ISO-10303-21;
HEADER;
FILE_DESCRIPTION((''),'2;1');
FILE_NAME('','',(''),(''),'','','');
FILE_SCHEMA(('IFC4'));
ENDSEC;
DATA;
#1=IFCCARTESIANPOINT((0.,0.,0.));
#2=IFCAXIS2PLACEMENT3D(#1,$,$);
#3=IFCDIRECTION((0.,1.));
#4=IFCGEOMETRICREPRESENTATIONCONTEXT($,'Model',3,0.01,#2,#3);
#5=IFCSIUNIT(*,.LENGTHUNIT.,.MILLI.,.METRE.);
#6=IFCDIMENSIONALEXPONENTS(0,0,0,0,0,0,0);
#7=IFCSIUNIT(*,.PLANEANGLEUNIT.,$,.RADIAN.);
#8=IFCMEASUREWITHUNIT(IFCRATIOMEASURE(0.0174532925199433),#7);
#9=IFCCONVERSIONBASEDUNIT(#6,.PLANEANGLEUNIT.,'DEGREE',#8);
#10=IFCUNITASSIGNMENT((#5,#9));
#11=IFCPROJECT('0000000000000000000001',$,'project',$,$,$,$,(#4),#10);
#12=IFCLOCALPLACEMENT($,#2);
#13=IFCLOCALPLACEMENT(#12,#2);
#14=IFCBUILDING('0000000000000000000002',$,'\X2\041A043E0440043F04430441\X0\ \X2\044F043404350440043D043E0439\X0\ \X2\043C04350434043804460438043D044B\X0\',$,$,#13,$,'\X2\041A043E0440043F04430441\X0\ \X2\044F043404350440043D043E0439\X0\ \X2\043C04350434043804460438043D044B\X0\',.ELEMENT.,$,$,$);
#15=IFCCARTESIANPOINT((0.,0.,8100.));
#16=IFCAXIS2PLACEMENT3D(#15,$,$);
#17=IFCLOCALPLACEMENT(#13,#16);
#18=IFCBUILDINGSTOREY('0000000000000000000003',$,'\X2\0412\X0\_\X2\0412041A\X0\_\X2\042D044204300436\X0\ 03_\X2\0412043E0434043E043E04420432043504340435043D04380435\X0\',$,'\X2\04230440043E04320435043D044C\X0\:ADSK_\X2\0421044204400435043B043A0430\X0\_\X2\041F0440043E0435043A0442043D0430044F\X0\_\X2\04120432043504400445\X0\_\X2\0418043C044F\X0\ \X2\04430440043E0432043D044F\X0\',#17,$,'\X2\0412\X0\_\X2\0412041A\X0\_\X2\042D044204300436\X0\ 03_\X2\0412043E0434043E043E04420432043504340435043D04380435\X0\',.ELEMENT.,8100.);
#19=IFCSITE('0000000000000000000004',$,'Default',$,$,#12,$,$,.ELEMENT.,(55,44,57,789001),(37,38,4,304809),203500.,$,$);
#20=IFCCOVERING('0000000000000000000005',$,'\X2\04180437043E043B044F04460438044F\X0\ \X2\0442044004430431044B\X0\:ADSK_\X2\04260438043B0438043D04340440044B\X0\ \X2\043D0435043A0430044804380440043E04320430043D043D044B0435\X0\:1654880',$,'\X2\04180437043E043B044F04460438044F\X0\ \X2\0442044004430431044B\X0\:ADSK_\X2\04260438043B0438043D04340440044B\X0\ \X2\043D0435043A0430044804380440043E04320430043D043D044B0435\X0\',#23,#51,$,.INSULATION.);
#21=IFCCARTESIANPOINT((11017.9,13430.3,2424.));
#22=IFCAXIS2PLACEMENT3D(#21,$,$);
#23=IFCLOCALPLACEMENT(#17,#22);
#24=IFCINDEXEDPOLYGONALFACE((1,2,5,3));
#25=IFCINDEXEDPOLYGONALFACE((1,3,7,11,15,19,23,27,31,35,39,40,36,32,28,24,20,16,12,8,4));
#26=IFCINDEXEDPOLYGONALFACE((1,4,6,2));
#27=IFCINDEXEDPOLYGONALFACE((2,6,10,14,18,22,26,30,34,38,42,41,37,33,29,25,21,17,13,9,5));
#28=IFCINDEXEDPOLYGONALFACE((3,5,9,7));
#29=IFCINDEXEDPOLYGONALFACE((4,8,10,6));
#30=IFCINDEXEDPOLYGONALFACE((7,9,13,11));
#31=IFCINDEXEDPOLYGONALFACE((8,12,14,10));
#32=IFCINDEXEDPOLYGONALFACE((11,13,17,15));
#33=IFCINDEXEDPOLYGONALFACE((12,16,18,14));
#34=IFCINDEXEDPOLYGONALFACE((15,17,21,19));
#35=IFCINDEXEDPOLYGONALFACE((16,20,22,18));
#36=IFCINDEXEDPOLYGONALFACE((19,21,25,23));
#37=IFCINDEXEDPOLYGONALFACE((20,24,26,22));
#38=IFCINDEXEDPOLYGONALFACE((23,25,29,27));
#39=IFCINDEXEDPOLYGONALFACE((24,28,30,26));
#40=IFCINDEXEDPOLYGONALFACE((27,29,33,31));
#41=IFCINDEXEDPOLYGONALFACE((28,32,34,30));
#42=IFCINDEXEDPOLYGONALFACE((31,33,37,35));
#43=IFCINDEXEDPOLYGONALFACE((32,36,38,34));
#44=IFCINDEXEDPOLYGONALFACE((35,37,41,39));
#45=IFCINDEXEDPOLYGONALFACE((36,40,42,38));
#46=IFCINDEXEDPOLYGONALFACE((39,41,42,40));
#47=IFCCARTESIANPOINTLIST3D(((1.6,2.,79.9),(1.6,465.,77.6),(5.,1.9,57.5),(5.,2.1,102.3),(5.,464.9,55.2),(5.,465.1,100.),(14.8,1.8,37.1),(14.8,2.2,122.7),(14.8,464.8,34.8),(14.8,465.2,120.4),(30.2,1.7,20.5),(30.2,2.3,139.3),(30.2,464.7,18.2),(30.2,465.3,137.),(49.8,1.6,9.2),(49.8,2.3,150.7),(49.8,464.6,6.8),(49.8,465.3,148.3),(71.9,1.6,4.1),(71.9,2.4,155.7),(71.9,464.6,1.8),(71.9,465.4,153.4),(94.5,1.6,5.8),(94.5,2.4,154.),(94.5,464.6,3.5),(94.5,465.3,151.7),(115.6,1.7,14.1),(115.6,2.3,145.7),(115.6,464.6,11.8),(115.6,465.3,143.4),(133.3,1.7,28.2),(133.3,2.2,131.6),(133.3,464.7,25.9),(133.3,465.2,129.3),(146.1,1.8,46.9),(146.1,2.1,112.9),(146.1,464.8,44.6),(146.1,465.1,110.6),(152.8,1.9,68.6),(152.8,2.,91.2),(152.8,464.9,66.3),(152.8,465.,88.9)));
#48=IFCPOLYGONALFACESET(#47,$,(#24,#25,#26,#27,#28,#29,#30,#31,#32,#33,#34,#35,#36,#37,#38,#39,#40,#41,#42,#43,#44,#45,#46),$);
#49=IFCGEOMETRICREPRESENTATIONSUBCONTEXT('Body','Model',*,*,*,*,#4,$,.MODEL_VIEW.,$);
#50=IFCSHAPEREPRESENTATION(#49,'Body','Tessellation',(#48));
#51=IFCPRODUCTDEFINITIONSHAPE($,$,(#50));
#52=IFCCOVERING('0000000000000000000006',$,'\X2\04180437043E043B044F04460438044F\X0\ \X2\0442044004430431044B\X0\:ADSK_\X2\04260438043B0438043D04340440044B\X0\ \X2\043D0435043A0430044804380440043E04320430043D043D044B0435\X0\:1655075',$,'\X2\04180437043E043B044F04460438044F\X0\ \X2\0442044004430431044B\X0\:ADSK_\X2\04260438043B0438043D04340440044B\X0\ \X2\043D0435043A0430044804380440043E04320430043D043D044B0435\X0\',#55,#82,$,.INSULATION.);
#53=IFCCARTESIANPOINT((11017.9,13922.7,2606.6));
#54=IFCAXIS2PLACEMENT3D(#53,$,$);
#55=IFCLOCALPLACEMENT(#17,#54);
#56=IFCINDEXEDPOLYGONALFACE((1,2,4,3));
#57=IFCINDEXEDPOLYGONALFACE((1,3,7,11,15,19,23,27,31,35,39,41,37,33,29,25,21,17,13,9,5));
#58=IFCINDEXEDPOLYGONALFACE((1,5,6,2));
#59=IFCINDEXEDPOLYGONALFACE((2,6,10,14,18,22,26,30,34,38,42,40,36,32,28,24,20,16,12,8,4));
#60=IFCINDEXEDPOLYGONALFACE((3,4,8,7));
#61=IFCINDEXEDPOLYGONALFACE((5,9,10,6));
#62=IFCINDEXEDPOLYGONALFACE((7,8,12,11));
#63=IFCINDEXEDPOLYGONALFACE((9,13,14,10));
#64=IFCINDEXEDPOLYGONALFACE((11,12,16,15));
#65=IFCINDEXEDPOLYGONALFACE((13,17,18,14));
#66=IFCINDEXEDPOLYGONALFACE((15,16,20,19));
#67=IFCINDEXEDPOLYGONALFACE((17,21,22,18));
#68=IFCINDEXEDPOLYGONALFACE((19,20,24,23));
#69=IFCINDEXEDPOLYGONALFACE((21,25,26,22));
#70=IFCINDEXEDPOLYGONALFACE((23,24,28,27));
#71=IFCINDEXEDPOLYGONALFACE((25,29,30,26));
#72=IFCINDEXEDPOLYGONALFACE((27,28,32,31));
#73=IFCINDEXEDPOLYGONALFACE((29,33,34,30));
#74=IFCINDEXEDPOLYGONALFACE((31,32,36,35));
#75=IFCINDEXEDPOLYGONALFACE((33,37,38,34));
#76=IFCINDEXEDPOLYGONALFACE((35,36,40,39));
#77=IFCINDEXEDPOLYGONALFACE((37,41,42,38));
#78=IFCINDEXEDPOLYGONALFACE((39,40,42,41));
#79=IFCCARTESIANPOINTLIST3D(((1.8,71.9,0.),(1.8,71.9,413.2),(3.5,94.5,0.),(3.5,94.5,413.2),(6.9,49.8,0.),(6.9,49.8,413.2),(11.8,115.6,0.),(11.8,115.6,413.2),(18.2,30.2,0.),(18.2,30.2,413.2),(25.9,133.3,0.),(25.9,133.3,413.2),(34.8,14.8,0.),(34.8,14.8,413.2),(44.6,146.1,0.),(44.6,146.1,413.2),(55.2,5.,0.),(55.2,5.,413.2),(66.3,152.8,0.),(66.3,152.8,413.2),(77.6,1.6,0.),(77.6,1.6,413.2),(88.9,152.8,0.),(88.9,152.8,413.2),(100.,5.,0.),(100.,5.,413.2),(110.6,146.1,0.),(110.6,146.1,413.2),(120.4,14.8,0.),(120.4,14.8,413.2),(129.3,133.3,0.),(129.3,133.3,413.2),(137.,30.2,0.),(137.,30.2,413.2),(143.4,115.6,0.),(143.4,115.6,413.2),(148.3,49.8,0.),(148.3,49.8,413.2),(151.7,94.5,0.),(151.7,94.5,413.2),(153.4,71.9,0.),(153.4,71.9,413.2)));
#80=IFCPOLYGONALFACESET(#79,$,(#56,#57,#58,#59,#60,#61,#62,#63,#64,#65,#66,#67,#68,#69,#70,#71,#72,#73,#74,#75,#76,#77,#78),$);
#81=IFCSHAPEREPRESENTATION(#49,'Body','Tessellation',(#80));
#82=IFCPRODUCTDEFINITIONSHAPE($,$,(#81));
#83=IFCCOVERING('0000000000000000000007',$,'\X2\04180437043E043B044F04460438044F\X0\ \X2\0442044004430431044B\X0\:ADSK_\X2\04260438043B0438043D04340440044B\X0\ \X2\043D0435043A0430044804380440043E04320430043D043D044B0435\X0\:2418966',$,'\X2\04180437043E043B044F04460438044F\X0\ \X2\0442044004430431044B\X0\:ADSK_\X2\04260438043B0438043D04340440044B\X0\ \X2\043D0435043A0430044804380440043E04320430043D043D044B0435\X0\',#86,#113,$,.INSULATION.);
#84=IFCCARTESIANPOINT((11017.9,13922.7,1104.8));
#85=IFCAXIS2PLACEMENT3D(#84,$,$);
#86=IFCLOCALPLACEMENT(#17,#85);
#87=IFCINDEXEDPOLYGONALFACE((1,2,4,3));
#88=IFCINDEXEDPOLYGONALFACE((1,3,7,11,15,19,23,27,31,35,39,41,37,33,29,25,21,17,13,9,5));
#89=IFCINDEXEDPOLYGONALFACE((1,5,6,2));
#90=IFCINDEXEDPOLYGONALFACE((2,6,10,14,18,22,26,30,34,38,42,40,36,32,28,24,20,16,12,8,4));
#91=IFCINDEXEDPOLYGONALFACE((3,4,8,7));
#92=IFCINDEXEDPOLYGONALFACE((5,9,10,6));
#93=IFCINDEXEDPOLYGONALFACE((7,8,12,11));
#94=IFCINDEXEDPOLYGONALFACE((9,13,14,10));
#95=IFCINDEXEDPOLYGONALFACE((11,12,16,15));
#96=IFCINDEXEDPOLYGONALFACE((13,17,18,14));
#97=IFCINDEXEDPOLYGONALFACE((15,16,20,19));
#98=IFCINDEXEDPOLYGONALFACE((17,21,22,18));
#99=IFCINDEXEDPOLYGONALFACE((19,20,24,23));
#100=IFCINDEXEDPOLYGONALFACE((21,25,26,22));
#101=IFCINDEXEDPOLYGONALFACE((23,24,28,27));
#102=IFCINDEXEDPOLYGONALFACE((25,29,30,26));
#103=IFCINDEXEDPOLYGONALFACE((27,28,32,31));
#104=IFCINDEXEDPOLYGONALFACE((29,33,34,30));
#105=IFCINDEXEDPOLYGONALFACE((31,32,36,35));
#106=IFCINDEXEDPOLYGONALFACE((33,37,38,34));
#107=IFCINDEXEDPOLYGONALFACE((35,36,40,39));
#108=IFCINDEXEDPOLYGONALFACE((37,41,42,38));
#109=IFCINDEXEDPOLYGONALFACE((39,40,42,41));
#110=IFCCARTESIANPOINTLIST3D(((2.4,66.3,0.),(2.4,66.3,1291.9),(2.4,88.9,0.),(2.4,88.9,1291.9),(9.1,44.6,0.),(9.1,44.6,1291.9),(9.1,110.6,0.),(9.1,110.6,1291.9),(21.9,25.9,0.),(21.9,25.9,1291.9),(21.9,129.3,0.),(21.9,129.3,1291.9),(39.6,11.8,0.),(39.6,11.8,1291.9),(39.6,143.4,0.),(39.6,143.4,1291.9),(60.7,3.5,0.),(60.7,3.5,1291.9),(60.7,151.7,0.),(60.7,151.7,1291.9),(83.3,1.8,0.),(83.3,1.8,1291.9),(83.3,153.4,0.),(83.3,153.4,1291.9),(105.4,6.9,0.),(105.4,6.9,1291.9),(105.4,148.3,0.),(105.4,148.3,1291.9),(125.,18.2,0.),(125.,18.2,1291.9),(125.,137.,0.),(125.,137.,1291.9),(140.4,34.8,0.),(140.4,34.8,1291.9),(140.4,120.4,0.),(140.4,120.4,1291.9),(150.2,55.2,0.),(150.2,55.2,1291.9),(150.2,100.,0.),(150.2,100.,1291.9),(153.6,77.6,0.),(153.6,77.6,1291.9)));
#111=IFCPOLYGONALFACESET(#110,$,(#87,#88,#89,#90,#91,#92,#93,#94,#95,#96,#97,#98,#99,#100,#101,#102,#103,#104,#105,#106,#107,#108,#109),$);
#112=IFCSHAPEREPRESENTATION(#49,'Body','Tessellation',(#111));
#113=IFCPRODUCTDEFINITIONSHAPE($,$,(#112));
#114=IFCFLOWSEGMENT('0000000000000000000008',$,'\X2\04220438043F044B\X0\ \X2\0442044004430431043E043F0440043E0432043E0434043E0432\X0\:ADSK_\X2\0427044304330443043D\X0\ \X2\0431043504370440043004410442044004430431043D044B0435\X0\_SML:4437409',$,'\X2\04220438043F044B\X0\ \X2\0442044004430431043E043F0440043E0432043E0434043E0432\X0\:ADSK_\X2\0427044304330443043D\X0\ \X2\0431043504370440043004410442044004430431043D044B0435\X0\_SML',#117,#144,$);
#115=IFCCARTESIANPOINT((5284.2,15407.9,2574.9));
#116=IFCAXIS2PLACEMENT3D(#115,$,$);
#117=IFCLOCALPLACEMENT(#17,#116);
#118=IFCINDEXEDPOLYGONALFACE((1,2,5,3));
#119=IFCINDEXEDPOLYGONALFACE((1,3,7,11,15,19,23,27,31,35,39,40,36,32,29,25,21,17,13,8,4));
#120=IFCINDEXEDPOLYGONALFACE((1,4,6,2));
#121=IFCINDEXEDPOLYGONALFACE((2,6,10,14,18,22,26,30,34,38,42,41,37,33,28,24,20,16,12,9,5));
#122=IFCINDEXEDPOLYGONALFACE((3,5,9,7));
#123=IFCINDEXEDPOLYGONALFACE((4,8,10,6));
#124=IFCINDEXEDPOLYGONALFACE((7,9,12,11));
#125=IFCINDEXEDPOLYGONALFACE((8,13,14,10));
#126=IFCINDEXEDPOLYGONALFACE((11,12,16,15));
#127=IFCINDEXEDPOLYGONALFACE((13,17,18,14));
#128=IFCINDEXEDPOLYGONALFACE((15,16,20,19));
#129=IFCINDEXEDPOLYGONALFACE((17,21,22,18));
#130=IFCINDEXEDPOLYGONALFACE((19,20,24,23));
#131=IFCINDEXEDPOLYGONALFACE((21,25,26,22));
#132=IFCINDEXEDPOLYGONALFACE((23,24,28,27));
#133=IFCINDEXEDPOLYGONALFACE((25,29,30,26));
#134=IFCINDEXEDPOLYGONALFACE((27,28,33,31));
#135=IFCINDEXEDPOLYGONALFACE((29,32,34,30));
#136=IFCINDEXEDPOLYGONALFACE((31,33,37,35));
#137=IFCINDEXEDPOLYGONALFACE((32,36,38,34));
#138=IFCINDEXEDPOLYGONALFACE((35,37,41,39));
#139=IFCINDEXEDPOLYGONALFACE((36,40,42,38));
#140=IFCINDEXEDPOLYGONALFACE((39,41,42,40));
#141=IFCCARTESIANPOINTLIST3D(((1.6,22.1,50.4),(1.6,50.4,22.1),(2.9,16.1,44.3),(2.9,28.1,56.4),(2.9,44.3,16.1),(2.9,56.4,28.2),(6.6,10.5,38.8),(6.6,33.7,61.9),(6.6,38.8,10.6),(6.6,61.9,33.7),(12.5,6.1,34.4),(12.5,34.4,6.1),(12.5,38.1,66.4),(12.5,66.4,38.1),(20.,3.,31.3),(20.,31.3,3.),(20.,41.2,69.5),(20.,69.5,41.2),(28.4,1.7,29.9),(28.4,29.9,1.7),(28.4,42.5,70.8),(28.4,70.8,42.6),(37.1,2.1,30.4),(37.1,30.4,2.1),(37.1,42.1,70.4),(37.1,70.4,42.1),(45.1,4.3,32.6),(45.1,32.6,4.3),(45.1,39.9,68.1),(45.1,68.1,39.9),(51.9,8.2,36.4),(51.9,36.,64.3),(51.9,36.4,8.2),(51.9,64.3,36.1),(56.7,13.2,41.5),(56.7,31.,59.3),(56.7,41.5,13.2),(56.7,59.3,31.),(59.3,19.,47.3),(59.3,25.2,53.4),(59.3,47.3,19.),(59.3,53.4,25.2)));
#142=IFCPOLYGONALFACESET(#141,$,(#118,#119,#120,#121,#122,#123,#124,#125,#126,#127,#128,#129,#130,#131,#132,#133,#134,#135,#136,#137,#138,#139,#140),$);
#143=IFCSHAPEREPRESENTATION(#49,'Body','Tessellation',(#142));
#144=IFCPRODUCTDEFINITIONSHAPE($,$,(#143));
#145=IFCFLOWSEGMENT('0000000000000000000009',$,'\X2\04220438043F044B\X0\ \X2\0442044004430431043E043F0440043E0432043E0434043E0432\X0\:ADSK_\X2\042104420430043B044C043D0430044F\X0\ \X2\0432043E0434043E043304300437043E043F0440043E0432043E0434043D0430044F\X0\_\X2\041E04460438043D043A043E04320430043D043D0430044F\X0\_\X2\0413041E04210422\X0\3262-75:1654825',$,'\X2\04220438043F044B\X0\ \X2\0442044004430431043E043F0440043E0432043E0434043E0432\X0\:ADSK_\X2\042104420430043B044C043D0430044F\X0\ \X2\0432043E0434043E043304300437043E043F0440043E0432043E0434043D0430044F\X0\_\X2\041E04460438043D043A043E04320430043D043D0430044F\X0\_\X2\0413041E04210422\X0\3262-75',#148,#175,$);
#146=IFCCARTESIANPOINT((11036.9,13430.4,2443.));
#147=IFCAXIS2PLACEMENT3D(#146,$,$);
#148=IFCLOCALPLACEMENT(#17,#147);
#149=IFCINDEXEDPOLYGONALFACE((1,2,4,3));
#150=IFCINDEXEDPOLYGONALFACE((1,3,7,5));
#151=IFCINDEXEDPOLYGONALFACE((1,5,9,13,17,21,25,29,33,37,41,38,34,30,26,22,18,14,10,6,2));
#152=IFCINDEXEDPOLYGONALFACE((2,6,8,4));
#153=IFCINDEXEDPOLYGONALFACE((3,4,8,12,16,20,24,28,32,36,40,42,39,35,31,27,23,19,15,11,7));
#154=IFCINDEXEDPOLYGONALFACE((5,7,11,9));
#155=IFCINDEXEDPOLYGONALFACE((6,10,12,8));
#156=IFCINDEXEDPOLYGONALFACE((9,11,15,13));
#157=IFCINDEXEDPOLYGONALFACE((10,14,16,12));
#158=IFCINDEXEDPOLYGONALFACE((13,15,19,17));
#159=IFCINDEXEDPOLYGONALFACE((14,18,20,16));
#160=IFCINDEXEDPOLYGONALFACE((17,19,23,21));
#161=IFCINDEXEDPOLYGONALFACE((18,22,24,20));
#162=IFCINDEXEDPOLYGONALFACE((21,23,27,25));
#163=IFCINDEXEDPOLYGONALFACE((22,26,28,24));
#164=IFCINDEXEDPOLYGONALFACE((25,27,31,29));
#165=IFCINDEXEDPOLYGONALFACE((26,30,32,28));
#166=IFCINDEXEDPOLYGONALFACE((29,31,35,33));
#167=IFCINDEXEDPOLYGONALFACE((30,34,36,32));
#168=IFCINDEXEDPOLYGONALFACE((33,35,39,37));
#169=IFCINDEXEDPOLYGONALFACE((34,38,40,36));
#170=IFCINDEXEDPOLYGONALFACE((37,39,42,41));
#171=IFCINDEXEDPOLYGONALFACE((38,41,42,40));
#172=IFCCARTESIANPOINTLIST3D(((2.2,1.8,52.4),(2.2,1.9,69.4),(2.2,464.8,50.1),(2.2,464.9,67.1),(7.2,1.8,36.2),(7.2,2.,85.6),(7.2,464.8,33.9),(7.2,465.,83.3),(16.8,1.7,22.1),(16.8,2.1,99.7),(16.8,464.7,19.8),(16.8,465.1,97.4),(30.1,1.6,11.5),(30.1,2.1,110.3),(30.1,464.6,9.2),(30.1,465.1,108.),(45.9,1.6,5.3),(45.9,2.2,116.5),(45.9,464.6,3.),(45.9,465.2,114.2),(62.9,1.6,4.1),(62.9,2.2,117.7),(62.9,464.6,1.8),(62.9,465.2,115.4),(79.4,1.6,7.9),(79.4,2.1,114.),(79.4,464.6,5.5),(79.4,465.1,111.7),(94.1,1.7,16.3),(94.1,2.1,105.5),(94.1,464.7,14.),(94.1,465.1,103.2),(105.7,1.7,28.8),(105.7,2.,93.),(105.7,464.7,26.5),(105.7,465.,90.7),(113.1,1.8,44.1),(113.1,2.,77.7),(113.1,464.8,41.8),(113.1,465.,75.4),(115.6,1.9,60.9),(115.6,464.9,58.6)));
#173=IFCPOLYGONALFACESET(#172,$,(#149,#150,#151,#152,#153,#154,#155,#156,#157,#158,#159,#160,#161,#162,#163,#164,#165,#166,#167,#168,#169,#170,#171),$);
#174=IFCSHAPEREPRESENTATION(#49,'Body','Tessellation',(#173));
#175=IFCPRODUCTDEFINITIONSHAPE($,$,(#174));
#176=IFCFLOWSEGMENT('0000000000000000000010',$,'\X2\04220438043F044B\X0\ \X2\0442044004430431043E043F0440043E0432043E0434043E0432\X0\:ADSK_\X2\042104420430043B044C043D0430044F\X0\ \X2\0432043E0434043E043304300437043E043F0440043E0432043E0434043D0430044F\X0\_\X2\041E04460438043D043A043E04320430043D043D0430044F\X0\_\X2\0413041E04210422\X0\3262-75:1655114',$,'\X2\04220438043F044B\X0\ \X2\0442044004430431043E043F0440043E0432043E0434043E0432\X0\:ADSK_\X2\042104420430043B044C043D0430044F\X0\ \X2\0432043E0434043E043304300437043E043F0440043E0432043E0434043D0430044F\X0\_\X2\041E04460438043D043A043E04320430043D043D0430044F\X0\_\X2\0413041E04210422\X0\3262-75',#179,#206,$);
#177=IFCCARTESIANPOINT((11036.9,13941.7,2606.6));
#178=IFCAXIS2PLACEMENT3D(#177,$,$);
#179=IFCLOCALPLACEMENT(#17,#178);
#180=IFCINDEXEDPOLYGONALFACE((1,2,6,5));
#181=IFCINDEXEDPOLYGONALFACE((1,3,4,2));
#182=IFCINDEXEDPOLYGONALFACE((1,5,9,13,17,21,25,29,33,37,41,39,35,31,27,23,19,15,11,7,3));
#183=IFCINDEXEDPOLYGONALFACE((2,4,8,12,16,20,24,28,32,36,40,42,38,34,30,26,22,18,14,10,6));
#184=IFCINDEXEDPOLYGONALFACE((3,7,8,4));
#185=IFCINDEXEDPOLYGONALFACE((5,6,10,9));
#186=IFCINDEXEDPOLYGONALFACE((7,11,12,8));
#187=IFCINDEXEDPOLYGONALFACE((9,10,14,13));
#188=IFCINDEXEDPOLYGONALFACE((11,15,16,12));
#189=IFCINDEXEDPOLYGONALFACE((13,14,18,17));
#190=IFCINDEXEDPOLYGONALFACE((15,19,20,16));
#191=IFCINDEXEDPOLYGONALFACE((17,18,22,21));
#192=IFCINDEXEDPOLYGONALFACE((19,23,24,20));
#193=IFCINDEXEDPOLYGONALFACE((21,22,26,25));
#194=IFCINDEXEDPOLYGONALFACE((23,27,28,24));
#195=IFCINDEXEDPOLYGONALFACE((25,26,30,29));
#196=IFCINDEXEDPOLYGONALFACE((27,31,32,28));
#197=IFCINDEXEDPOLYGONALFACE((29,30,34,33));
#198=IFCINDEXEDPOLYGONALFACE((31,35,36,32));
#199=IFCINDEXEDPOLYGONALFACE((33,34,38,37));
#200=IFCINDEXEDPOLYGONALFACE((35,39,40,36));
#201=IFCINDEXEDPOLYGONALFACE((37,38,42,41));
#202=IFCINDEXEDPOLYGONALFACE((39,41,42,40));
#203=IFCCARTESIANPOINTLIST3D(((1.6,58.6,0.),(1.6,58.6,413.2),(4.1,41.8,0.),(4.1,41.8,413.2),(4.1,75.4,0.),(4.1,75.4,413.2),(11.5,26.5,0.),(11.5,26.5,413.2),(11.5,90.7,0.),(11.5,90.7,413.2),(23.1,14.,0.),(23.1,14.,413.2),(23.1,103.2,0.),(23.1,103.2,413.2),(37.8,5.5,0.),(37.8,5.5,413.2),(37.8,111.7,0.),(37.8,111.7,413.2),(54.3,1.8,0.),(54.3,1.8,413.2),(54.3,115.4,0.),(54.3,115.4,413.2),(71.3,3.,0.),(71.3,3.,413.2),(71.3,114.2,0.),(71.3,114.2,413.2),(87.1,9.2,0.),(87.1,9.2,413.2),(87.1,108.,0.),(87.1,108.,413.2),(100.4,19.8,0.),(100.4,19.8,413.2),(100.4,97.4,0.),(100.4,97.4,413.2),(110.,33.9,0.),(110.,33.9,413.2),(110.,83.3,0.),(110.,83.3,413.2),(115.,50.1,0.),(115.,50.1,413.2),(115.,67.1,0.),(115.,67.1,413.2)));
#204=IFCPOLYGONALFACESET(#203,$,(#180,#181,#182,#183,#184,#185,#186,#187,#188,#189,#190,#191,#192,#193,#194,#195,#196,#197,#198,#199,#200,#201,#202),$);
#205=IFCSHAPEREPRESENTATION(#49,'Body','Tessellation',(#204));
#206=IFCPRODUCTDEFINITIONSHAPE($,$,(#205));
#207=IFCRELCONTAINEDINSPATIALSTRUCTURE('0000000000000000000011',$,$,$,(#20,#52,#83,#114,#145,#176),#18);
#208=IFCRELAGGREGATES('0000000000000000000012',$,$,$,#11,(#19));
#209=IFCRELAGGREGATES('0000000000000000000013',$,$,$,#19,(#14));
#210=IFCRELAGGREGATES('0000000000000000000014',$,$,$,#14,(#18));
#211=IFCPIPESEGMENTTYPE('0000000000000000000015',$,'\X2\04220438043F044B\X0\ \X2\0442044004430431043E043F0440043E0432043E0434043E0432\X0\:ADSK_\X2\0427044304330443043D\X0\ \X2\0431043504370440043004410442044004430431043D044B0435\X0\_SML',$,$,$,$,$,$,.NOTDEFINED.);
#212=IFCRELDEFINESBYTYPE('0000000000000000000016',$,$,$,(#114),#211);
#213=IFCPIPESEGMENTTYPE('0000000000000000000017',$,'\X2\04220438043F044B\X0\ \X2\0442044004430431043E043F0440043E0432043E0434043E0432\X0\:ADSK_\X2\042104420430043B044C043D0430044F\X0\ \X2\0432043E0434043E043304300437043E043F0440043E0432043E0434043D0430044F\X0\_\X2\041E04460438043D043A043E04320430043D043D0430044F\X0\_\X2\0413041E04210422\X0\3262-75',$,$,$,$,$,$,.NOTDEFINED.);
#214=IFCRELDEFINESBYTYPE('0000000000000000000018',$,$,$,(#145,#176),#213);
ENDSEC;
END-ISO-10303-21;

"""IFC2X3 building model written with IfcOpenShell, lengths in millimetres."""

from ifc_helpers import new_model, entity, si_unit, converted_unit, direction, frame, origin, origin_2d_with_axis, place, context, subcontext, project, spatial, circle, extrude, type_object, element, save


model = new_model("IFC2X3")

# Units and contexts
model_context = context("Model", 3, precision=0.01, world=origin(), true_north=direction((0.0, 1.0)))
body_context = subcontext(model_context, "Body", "Model", "MODEL_VIEW")
ifc_project = project(units=[si_unit("LENGTHUNIT", "METRE", prefix="MILLI"), converted_unit("PLANEANGLEUNIT", "DEGREE", entity("IfcRatioMeasure", 0.0174532925199433), si_unit("PLANEANGLEUNIT", "RADIAN"), dimensions=[0, 0, 0, 0, 0, 0, 0])], contexts=[model_context])

# Site, building, storey
site_placement = place(None, origin())
site = spatial("IfcSite", under=ifc_project, at=site_placement, Name="Default", CompositionType="ELEMENT", RefLatitude=(55, 44, 57, 789001), RefLongitude=(37, 38, 4, 304809), RefElevation=203500.0)
building_placement = place(site_placement, origin())
building = spatial("IfcBuilding", under=site, at=building_placement, Name="Корпус ядерной медицины", LongName="Корпус ядерной медицины", CompositionType="ELEMENT")
storey_placement = place(building_placement, frame((0.0, 0.0, 8100.0)))
storey = spatial("IfcBuildingStorey", under=building, at=storey_placement, Name="В_ВК_Этаж 03_Водоотведение", ObjectType="Уровень:ADSK_Стрелка_Проектная_Вверх_Имя уровня", LongName="В_ВК_Этаж 03_Водоотведение", CompositionType="ELEMENT", Elevation=8100.0)

# Coverings
covering_1_placement = place(storey_placement, frame((11017.9, 13430.3, 2424.0)))
element("IfcCovering", 1, at=covering_1_placement, inside=storey, Name="Изоляция трубы:ADSK_Цилиндры некашированные:1654880", ObjectType="Изоляция трубы:ADSK_Цилиндры некашированные", PredefinedType="INSULATION", context=body_context, shape_type="SweptSolid", body=[
    extrude(circle(Radius=76.0, at=origin_2d_with_axis()), frame((77.6, 2.0, 79.9), z_axis=(0.0, 0.999988, -0.005), x_axis=(-1.0, 0.0, 0.0)), (0.0, 0.0, 1.0), 463.0),
])
covering_2_placement = place(storey_placement, frame((11017.9, 13922.7, 2606.6)))
element("IfcCovering", 2, at=covering_2_placement, inside=storey, Name="Изоляция трубы:ADSK_Цилиндры некашированные:1655075", ObjectType="Изоляция трубы:ADSK_Цилиндры некашированные", PredefinedType="INSULATION", context=body_context, shape_type="SweptSolid", body=[
    extrude(circle(Radius=76.0, at=origin_2d_with_axis()), frame((77.6, 77.6, 0.0), z_axis=(0.0, 0.0, 1.0), x_axis=(0.0, -1.0, 0.0)), (0.0, 0.0, 1.0), 413.2),
])
covering_3_placement = place(storey_placement, frame((11017.9, 13922.7, 1104.8)))
element("IfcCovering", 3, at=covering_3_placement, inside=storey, Name="Изоляция трубы:ADSK_Цилиндры некашированные:2418966", ObjectType="Изоляция трубы:ADSK_Цилиндры некашированные", PredefinedType="INSULATION", context=body_context, shape_type="SweptSolid", body=[
    extrude(circle(Radius=76.0, at=origin_2d_with_axis()), frame((77.6, 77.6, 0.0)), (0.0, 0.0, 1.0), 1291.9),
])

# Flow segments
pipe_segment_type_1 = type_object("IfcPipeSegmentType", Name="Типы трубопроводов:ADSK_Чугун безраструбные_SML", PredefinedType="NOTDEFINED")
flow_segment_1_placement = place(storey_placement, frame((5284.2, 15407.9, 2574.9)))
element("IfcFlowSegment", 4, at=flow_segment_1_placement, inside=storey, type_object=pipe_segment_type_1, Name="Типы трубопроводов:ADSK_Чугун безраструбные_SML:4437409", ObjectType="Типы трубопроводов:ADSK_Чугун безраструбные_SML", context=body_context, shape_type="SweptSolid", body=[
    extrude(circle(Radius=29.0, at=origin_2d_with_axis()), frame((30.6, 22.1, 50.4), z_axis=(0.0, 0.707107, -0.707107), x_axis=(-1.0, 0.0, 0.0)), (0.0, 0.0, 1.0), 40.0),
])
pipe_segment_type_2 = type_object("IfcPipeSegmentType", Name="Типы трубопроводов:ADSK_Стальная водогазопроводная_Оцинкованная_ГОСТ3262-75", PredefinedType="NOTDEFINED")
flow_segment_2_placement = place(storey_placement, frame((11036.9, 13430.4, 2443.0)))
element("IfcFlowSegment", 5, at=flow_segment_2_placement, inside=storey, type_object=pipe_segment_type_2, Name="Типы трубопроводов:ADSK_Стальная водогазопроводная_Оцинкованная_ГОСТ3262-75:1654825", ObjectType="Типы трубопроводов:ADSK_Стальная водогазопроводная_Оцинкованная_ГОСТ3262-75", context=body_context, shape_type="SweptSolid", body=[
    extrude(circle(Radius=57.0, at=origin_2d_with_axis()), frame((58.6, 1.9, 60.9), z_axis=(0.0, 0.999988, -0.005), x_axis=(1.0, 0.0, 0.0)), (0.0, 0.0, 1.0), 463.0),
])
flow_segment_3_placement = place(storey_placement, frame((11036.9, 13941.7, 2606.6)))
element("IfcFlowSegment", 6, at=flow_segment_3_placement, inside=storey, type_object=pipe_segment_type_2, Name="Типы трубопроводов:ADSK_Стальная водогазопроводная_Оцинкованная_ГОСТ3262-75:1655114", ObjectType="Типы трубопроводов:ADSK_Стальная водогазопроводная_Оцинкованная_ГОСТ3262-75", context=body_context, shape_type="SweptSolid", body=[
    extrude(circle(Radius=57.0, at=origin_2d_with_axis()), frame((58.6, 58.6, 0.0), z_axis=(0.0, 0.0, 1.0), x_axis=(-1.0, 0.0, 0.0)), (0.0, 0.0, 1.0), 413.2),
])

save(model, "model.ifc")
